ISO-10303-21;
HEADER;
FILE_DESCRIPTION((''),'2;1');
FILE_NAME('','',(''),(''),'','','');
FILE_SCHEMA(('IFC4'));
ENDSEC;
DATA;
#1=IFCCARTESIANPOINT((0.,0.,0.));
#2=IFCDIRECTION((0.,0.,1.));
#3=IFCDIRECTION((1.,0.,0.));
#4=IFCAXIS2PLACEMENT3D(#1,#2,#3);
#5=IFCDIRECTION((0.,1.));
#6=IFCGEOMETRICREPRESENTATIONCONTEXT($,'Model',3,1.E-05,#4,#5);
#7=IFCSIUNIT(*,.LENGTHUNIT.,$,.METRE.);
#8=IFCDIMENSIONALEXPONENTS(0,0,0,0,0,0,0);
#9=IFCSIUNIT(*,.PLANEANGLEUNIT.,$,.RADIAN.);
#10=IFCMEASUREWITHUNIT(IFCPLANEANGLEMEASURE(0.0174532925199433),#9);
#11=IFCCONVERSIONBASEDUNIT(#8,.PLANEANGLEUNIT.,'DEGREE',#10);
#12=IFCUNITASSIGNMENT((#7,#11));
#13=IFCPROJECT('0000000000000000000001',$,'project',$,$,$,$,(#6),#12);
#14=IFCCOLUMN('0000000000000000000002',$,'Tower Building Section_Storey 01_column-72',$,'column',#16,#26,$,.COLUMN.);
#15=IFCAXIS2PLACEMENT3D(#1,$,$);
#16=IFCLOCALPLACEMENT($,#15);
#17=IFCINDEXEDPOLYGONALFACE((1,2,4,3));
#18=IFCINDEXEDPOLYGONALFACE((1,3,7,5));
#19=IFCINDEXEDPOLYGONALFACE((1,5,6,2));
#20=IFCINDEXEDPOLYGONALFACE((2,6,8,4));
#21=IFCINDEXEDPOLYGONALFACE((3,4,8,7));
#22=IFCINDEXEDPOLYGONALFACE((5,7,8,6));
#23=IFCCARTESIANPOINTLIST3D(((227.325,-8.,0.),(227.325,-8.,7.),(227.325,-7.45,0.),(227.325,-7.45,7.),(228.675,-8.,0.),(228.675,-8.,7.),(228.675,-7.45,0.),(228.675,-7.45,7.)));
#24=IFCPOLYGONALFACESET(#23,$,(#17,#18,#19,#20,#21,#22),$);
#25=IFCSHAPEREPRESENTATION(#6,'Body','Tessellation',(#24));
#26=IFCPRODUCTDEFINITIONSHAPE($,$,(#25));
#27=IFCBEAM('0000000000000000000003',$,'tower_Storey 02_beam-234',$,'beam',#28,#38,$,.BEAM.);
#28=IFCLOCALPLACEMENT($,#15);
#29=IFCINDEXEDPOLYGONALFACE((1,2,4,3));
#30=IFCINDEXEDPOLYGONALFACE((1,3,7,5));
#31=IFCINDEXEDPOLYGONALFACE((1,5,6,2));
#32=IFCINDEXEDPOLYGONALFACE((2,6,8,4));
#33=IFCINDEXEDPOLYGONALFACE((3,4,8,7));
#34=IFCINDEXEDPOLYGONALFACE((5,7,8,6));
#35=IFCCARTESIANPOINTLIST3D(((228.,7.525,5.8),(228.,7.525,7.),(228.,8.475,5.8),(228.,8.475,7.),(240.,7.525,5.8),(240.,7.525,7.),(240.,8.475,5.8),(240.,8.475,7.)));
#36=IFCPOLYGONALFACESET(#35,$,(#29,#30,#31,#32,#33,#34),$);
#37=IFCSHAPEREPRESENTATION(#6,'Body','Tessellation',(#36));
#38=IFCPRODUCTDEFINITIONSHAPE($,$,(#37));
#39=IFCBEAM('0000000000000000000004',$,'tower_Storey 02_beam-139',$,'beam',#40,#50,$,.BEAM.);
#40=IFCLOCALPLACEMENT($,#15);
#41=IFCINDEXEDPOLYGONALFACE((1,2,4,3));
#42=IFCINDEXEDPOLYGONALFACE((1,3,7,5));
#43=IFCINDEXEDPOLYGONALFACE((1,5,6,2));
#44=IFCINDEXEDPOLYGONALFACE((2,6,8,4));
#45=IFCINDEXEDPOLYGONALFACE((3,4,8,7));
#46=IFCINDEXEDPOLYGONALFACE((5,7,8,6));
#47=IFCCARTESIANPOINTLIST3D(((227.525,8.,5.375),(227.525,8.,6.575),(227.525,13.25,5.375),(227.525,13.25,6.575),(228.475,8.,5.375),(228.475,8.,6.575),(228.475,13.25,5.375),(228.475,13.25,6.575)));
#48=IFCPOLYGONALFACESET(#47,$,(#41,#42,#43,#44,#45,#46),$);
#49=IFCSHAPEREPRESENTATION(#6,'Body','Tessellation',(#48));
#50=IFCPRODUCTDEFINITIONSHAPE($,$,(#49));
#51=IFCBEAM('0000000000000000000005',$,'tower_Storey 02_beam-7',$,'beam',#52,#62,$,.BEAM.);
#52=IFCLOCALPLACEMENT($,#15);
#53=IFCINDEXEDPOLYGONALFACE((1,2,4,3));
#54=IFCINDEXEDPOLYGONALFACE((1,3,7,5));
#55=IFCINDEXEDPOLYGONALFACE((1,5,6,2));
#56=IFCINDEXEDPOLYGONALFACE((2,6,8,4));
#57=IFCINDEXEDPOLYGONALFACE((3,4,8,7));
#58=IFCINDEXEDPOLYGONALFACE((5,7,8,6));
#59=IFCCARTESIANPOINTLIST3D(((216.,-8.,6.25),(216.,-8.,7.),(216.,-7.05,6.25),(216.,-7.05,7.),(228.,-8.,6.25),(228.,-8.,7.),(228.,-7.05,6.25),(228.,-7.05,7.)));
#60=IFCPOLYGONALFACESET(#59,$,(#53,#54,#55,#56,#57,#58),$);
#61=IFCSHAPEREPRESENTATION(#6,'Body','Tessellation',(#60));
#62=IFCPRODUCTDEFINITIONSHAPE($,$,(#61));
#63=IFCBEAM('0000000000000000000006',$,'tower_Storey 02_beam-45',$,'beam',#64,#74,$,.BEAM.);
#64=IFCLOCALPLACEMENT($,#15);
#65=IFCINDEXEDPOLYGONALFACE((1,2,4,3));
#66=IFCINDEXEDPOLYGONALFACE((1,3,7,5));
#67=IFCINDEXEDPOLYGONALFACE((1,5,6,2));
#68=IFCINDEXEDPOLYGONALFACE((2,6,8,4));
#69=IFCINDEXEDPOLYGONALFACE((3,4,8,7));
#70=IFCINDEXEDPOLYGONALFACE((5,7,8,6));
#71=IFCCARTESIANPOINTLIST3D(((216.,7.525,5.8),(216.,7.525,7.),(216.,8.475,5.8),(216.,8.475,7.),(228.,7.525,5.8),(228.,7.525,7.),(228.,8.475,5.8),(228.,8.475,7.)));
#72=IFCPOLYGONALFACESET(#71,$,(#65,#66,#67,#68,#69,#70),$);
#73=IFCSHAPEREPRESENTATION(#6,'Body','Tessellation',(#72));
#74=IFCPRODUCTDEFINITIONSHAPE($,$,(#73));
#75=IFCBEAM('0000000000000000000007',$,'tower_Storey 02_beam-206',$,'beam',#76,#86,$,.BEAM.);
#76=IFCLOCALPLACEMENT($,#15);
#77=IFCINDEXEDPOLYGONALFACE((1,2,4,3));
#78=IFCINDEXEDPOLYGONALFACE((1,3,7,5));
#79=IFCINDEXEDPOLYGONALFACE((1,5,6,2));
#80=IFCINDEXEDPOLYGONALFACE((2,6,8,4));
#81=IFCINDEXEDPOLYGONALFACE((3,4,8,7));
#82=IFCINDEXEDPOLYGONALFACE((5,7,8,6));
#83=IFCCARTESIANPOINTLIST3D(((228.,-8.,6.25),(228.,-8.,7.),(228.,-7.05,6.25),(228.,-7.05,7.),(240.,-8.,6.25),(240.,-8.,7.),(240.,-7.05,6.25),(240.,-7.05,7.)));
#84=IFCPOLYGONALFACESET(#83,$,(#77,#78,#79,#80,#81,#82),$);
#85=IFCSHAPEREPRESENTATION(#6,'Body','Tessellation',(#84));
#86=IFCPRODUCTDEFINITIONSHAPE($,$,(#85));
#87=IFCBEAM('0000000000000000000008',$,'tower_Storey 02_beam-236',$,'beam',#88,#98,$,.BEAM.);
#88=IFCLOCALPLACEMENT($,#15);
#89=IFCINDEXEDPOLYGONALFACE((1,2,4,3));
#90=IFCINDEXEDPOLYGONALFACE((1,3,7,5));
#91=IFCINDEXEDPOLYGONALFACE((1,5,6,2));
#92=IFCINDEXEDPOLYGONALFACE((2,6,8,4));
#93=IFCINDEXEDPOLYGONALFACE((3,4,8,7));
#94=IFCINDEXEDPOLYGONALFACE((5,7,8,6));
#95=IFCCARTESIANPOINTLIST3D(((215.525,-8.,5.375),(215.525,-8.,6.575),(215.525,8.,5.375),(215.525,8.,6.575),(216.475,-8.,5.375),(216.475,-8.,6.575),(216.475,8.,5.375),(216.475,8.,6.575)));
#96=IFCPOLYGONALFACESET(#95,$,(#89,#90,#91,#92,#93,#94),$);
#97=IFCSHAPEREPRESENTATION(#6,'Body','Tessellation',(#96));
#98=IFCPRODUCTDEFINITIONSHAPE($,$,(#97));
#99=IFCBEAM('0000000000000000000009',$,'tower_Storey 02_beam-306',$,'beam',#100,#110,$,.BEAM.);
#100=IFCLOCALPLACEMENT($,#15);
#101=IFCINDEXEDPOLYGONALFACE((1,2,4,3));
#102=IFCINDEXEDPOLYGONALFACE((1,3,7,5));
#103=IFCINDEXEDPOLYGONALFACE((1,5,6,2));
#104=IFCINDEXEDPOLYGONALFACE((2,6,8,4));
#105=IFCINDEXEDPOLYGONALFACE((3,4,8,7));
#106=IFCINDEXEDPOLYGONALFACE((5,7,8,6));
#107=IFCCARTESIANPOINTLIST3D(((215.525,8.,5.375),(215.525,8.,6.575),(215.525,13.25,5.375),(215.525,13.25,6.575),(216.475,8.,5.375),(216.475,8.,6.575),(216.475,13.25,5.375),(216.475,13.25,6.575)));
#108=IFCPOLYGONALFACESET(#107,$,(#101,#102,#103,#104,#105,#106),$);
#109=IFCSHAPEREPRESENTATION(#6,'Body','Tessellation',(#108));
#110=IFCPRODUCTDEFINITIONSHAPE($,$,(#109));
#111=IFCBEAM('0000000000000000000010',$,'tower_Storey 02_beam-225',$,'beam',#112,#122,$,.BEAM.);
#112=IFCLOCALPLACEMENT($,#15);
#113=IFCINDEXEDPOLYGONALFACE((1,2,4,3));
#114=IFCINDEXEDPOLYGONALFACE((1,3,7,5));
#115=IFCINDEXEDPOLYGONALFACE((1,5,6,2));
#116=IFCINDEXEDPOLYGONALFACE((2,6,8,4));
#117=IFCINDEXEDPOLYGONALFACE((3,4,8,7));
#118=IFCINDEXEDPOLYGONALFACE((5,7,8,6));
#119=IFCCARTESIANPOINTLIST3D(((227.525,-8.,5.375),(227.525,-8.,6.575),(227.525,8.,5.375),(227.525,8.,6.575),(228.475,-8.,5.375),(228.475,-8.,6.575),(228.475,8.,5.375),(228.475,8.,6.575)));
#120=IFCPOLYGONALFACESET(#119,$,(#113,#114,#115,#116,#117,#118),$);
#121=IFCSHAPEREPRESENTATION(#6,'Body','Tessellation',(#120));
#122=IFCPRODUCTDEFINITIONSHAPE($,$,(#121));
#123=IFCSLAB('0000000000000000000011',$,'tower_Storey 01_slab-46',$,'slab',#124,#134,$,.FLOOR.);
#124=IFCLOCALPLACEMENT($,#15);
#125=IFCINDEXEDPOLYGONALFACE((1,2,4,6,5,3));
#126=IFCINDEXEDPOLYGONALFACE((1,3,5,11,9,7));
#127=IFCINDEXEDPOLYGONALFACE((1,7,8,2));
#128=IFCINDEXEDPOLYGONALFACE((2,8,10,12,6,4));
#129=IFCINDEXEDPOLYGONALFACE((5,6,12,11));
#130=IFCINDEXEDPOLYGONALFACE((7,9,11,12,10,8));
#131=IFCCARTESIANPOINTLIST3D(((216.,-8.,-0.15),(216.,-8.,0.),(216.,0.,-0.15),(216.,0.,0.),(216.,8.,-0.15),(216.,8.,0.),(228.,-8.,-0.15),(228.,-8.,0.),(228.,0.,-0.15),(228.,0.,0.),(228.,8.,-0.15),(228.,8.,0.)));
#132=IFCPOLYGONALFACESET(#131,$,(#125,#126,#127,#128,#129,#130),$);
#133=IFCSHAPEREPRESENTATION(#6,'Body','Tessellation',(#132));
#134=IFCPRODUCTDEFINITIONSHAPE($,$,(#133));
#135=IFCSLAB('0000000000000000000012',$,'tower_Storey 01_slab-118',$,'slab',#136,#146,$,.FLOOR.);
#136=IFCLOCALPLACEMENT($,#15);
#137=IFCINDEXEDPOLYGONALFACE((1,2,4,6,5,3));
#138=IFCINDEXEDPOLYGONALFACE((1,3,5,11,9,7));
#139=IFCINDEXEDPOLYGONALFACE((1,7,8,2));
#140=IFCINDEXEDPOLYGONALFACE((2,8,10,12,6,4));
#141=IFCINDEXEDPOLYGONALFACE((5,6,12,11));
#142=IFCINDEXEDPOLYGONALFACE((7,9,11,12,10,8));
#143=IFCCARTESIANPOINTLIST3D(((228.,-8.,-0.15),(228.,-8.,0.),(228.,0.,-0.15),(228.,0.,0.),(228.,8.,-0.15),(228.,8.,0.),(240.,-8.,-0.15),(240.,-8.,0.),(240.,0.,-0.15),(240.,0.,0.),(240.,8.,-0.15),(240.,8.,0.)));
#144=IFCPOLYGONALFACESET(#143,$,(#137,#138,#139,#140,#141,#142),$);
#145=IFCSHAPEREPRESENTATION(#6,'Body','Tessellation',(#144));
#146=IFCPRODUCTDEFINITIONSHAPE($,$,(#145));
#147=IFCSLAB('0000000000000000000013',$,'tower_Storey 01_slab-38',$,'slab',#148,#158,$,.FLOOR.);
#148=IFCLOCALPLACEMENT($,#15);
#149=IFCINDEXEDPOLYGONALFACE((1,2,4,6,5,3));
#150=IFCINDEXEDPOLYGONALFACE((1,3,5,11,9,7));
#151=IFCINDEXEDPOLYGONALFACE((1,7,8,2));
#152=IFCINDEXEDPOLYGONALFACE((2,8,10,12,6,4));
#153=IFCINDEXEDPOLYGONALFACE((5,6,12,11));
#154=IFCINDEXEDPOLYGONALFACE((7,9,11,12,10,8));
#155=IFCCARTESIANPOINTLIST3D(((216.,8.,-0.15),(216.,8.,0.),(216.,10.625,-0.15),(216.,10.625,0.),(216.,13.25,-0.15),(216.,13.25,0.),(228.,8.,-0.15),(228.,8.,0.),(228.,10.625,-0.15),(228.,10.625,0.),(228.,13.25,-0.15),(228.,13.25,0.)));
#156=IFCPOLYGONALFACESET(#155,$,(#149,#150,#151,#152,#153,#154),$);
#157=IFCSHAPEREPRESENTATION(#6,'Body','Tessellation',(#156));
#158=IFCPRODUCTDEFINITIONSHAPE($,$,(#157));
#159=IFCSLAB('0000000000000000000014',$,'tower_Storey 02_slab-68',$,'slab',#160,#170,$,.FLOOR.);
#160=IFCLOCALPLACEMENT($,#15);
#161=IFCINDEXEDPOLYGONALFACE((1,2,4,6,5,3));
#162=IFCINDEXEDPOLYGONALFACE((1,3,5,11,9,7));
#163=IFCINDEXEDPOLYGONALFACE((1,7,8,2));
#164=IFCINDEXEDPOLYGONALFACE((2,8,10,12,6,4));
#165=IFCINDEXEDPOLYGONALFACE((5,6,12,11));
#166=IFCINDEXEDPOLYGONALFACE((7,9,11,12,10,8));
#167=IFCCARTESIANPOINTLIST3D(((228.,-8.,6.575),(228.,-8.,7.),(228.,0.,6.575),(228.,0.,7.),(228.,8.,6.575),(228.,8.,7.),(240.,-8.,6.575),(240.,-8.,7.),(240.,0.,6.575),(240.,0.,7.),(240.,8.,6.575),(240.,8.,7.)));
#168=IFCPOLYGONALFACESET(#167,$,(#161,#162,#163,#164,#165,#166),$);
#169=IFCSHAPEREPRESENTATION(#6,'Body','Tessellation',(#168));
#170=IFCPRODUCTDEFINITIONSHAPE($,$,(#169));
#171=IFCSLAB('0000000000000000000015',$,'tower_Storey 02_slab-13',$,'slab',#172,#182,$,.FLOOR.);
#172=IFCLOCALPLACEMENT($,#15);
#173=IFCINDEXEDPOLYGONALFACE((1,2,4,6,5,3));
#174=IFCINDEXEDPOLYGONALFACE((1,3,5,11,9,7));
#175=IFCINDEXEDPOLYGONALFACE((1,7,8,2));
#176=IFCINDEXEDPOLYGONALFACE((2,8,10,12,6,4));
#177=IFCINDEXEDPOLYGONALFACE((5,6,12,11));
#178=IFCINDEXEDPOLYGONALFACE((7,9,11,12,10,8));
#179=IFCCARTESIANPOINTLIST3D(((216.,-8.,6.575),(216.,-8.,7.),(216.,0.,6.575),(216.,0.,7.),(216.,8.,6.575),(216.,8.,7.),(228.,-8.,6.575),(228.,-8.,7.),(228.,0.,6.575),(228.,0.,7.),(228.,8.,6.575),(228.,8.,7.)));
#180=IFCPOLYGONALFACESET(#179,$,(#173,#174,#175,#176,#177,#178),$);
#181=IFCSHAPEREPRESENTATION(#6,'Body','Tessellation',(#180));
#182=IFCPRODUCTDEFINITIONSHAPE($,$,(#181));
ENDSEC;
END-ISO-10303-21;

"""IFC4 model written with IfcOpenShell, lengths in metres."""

from ifc_helpers import new_model, entity, si_unit, converted_unit, direction, frame, origin_with_axes, place, context, project, polyline, outline, extrude, element, save


model = new_model("IFC4")

# Units and contexts
model_context = context("Model", 3, precision=1e-05, world=origin_with_axes(), true_north=direction((0.0, 1.0)))
ifc_project = project(units=[si_unit("LENGTHUNIT", "METRE"), converted_unit("PLANEANGLEUNIT", "DEGREE", entity("IfcPlaneAngleMeasure", 0.0174532925199433), si_unit("PLANEANGLEUNIT", "RADIAN"), dimensions=[0, 0, 0, 0, 0, 0, 0])], contexts=[model_context])

# Shared definitions
placement_1 = place(None, origin_with_axes())
placement_2 = place(placement_1, origin_with_axes())

# Column
placement_3 = place(placement_1, frame((0.0, 0.0, 7.0), z_axis=(0.0, 0.0, 1.0), x_axis=(1.0, 0.0, 0.0)))
column_1_placement = place(placement_2, frame((228.0, -7.725, 0.0), z_axis=(0.0, 0.0, 1.0), x_axis=(1.0, 0.0, 0.0)))
element("IfcColumn", 1, at=column_1_placement, Name="Tower Building Section_Storey 01_column-72", ObjectType="column", PredefinedType="COLUMN", context=model_context, body=[
    extrude(outline(polyline([(-0.675, -0.275, 0.0), (0.675, -0.275, 0.0), (0.675, 0.275, 0.0), (-0.675, 0.275, 0.0), (-0.675, -0.275, 0.0)])), origin_with_axes(), (0.0, 0.0, 1.0), 7.0),
])

# Beams
beam_1_placement = place(placement_3, frame((228.0, 8.0, -0.6), z_axis=(1.0, 0.0, 0.0), x_axis=(0.0, 1.0, 0.0)))
element("IfcBeam", 2, at=beam_1_placement, Name="tower_Storey 02_beam-234", ObjectType="beam", PredefinedType="BEAM", context=model_context, body=[
    extrude(outline(polyline([(0.475, 0.6, 0.0), (-0.475, 0.6, 0.0), (-0.475, -0.6, 0.0), (0.475, -0.6, 0.0), (0.475, 0.6, 0.0)])), origin_with_axes(), (0.0, 0.0, 1.0), 12.0),
])
beam_2_placement = place(placement_3, frame((228.0, 8.0, -1.025), z_axis=(0.0, 1.0, 0.0), x_axis=(-1.0, 0.0, 0.0)))
element("IfcBeam", 3, at=beam_2_placement, Name="tower_Storey 02_beam-139", ObjectType="beam", PredefinedType="BEAM", context=model_context, body=[
    extrude(outline(polyline([(0.475, 0.6, 0.0), (-0.475, 0.6, 0.0), (-0.475, -0.6, 0.0), (0.475, -0.6, 0.0), (0.475, 0.6, 0.0)])), origin_with_axes(), (0.0, 0.0, 1.0), 5.25),
])
beam_3_placement = place(placement_3, frame((216.0, -7.525, -0.375), z_axis=(1.0, 0.0, 0.0), x_axis=(0.0, 1.0, 0.0)))
element("IfcBeam", 4, at=beam_3_placement, Name="tower_Storey 02_beam-7", ObjectType="beam", PredefinedType="BEAM", context=model_context, body=[
    extrude(outline(polyline([(0.475, 0.375, 0.0), (-0.475, 0.375, 0.0), (-0.475, -0.375, 0.0), (0.475, -0.375, 0.0), (0.475, 0.375, 0.0)])), origin_with_axes(), (0.0, 0.0, 1.0), 12.0),
])
beam_4_placement = place(placement_3, frame((216.0, 8.0, -0.6), z_axis=(1.0, 0.0, 0.0), x_axis=(0.0, 1.0, 0.0)))
element("IfcBeam", 5, at=beam_4_placement, Name="tower_Storey 02_beam-45", ObjectType="beam", PredefinedType="BEAM", context=model_context, body=[
    extrude(outline(polyline([(0.475, 0.6, 0.0), (-0.475, 0.6, 0.0), (-0.475, -0.6, 0.0), (0.475, -0.6, 0.0), (0.475, 0.6, 0.0)])), origin_with_axes(), (0.0, 0.0, 1.0), 12.0),
])
beam_5_placement = place(placement_3, frame((228.0, -7.525, -0.375), z_axis=(1.0, 0.0, 0.0), x_axis=(0.0, 1.0, 0.0)))
element("IfcBeam", 6, at=beam_5_placement, Name="tower_Storey 02_beam-206", ObjectType="beam", PredefinedType="BEAM", context=model_context, body=[
    extrude(outline(polyline([(0.475, 0.375, 0.0), (-0.475, 0.375, 0.0), (-0.475, -0.375, 0.0), (0.475, -0.375, 0.0), (0.475, 0.375, 0.0)])), origin_with_axes(), (0.0, 0.0, 1.0), 12.0),
])
beam_6_placement = place(placement_3, frame((216.0, -8.0, -1.025), z_axis=(0.0, 1.0, 0.0), x_axis=(-1.0, 0.0, 0.0)))
element("IfcBeam", 7, at=beam_6_placement, Name="tower_Storey 02_beam-236", ObjectType="beam", PredefinedType="BEAM", context=model_context, body=[
    extrude(outline(polyline([(0.475, 0.6, 0.0), (-0.475, 0.6, 0.0), (-0.475, -0.6, 0.0), (0.475, -0.6, 0.0), (0.475, 0.6, 0.0)])), origin_with_axes(), (0.0, 0.0, 1.0), 16.0),
])
beam_7_placement = place(placement_3, frame((216.0, 8.0, -1.025), z_axis=(0.0, 1.0, 0.0), x_axis=(-1.0, 0.0, 0.0)))
element("IfcBeam", 8, at=beam_7_placement, Name="tower_Storey 02_beam-306", ObjectType="beam", PredefinedType="BEAM", context=model_context, body=[
    extrude(outline(polyline([(0.475, 0.6, 0.0), (-0.475, 0.6, 0.0), (-0.475, -0.6, 0.0), (0.475, -0.6, 0.0), (0.475, 0.6, 0.0)])), origin_with_axes(), (0.0, 0.0, 1.0), 5.25),
])
beam_8_placement = place(placement_3, frame((228.0, -8.0, -1.025), z_axis=(0.0, 1.0, 0.0), x_axis=(-1.0, 0.0, 0.0)))
element("IfcBeam", 9, at=beam_8_placement, Name="tower_Storey 02_beam-225", ObjectType="beam", PredefinedType="BEAM", context=model_context, body=[
    extrude(outline(polyline([(0.475, 0.6, 0.0), (-0.475, 0.6, 0.0), (-0.475, -0.6, 0.0), (0.475, -0.6, 0.0), (0.475, 0.6, 0.0)])), origin_with_axes(), (0.0, 0.0, 1.0), 16.0),
])

# Slabs
for number, where, z_axis, x_axis, name in (
    (10, (222.0, 0.0, -0.15), (0.0, 0.0, 1.0), (1.0, 0.0, 0.0), "tower_Storey 01_slab-46"),
    (11, (234.0, 0.0, -0.15), (0.0, 0.0, 1.0), (1.0, 0.0, 0.0), "tower_Storey 01_slab-118"),
):
    element("IfcSlab", number, at=place(placement_2, frame(where, z_axis=z_axis, x_axis=x_axis)), Name=name, ObjectType="slab", PredefinedType="FLOOR", context=model_context, body=[
        extrude(outline(polyline([(-6.0, -8.0, 0.0), (6.0, -8.0, 0.0), (6.0, 0.0, 0.0), (6.0, 8.0, 0.0), (-6.0, 8.0, 0.0), (-6.0, 0.0, 0.0), (-6.0, -8.0, 0.0)])), origin_with_axes(), (0.0, 0.0, 1.0), 0.15),
    ])
slab_placement = place(placement_2, frame((222.0, 10.625, -0.15), z_axis=(0.0, 0.0, 1.0), x_axis=(1.0, 0.0, 0.0)))
element("IfcSlab", 12, at=slab_placement, Name="tower_Storey 01_slab-38", ObjectType="slab", PredefinedType="FLOOR", context=model_context, body=[
    extrude(outline(polyline([(-6.0, -2.625, 0.0), (6.0, -2.625, 0.0), (6.0, 0.0, 0.0), (6.0, 2.625, 0.0), (-6.0, 2.625, 0.0), (-6.0, 0.0, 0.0), (-6.0, -2.625, 0.0)])), origin_with_axes(), (0.0, 0.0, 1.0), 0.15),
])
for number, where, z_axis, x_axis, name in (
    (13, (234.0, 0.0, -0.425), (0.0, 0.0, 1.0), (1.0, 0.0, 0.0), "tower_Storey 02_slab-68"),
    (14, (222.0, 0.0, -0.425), (0.0, 0.0, 1.0), (1.0, 0.0, 0.0), "tower_Storey 02_slab-13"),
):
    element("IfcSlab", number, at=place(placement_3, frame(where, z_axis=z_axis, x_axis=x_axis)), Name=name, ObjectType="slab", PredefinedType="FLOOR", context=model_context, body=[
        extrude(outline(polyline([(-6.0, -8.0, 0.0), (6.0, -8.0, 0.0), (6.0, 0.0, 0.0), (6.0, 8.0, 0.0), (-6.0, 8.0, 0.0), (-6.0, 0.0, 0.0), (-6.0, -8.0, 0.0)])), origin_with_axes(), (0.0, 0.0, 1.0), 0.425),
    ])

save(model, "model.ifc")
